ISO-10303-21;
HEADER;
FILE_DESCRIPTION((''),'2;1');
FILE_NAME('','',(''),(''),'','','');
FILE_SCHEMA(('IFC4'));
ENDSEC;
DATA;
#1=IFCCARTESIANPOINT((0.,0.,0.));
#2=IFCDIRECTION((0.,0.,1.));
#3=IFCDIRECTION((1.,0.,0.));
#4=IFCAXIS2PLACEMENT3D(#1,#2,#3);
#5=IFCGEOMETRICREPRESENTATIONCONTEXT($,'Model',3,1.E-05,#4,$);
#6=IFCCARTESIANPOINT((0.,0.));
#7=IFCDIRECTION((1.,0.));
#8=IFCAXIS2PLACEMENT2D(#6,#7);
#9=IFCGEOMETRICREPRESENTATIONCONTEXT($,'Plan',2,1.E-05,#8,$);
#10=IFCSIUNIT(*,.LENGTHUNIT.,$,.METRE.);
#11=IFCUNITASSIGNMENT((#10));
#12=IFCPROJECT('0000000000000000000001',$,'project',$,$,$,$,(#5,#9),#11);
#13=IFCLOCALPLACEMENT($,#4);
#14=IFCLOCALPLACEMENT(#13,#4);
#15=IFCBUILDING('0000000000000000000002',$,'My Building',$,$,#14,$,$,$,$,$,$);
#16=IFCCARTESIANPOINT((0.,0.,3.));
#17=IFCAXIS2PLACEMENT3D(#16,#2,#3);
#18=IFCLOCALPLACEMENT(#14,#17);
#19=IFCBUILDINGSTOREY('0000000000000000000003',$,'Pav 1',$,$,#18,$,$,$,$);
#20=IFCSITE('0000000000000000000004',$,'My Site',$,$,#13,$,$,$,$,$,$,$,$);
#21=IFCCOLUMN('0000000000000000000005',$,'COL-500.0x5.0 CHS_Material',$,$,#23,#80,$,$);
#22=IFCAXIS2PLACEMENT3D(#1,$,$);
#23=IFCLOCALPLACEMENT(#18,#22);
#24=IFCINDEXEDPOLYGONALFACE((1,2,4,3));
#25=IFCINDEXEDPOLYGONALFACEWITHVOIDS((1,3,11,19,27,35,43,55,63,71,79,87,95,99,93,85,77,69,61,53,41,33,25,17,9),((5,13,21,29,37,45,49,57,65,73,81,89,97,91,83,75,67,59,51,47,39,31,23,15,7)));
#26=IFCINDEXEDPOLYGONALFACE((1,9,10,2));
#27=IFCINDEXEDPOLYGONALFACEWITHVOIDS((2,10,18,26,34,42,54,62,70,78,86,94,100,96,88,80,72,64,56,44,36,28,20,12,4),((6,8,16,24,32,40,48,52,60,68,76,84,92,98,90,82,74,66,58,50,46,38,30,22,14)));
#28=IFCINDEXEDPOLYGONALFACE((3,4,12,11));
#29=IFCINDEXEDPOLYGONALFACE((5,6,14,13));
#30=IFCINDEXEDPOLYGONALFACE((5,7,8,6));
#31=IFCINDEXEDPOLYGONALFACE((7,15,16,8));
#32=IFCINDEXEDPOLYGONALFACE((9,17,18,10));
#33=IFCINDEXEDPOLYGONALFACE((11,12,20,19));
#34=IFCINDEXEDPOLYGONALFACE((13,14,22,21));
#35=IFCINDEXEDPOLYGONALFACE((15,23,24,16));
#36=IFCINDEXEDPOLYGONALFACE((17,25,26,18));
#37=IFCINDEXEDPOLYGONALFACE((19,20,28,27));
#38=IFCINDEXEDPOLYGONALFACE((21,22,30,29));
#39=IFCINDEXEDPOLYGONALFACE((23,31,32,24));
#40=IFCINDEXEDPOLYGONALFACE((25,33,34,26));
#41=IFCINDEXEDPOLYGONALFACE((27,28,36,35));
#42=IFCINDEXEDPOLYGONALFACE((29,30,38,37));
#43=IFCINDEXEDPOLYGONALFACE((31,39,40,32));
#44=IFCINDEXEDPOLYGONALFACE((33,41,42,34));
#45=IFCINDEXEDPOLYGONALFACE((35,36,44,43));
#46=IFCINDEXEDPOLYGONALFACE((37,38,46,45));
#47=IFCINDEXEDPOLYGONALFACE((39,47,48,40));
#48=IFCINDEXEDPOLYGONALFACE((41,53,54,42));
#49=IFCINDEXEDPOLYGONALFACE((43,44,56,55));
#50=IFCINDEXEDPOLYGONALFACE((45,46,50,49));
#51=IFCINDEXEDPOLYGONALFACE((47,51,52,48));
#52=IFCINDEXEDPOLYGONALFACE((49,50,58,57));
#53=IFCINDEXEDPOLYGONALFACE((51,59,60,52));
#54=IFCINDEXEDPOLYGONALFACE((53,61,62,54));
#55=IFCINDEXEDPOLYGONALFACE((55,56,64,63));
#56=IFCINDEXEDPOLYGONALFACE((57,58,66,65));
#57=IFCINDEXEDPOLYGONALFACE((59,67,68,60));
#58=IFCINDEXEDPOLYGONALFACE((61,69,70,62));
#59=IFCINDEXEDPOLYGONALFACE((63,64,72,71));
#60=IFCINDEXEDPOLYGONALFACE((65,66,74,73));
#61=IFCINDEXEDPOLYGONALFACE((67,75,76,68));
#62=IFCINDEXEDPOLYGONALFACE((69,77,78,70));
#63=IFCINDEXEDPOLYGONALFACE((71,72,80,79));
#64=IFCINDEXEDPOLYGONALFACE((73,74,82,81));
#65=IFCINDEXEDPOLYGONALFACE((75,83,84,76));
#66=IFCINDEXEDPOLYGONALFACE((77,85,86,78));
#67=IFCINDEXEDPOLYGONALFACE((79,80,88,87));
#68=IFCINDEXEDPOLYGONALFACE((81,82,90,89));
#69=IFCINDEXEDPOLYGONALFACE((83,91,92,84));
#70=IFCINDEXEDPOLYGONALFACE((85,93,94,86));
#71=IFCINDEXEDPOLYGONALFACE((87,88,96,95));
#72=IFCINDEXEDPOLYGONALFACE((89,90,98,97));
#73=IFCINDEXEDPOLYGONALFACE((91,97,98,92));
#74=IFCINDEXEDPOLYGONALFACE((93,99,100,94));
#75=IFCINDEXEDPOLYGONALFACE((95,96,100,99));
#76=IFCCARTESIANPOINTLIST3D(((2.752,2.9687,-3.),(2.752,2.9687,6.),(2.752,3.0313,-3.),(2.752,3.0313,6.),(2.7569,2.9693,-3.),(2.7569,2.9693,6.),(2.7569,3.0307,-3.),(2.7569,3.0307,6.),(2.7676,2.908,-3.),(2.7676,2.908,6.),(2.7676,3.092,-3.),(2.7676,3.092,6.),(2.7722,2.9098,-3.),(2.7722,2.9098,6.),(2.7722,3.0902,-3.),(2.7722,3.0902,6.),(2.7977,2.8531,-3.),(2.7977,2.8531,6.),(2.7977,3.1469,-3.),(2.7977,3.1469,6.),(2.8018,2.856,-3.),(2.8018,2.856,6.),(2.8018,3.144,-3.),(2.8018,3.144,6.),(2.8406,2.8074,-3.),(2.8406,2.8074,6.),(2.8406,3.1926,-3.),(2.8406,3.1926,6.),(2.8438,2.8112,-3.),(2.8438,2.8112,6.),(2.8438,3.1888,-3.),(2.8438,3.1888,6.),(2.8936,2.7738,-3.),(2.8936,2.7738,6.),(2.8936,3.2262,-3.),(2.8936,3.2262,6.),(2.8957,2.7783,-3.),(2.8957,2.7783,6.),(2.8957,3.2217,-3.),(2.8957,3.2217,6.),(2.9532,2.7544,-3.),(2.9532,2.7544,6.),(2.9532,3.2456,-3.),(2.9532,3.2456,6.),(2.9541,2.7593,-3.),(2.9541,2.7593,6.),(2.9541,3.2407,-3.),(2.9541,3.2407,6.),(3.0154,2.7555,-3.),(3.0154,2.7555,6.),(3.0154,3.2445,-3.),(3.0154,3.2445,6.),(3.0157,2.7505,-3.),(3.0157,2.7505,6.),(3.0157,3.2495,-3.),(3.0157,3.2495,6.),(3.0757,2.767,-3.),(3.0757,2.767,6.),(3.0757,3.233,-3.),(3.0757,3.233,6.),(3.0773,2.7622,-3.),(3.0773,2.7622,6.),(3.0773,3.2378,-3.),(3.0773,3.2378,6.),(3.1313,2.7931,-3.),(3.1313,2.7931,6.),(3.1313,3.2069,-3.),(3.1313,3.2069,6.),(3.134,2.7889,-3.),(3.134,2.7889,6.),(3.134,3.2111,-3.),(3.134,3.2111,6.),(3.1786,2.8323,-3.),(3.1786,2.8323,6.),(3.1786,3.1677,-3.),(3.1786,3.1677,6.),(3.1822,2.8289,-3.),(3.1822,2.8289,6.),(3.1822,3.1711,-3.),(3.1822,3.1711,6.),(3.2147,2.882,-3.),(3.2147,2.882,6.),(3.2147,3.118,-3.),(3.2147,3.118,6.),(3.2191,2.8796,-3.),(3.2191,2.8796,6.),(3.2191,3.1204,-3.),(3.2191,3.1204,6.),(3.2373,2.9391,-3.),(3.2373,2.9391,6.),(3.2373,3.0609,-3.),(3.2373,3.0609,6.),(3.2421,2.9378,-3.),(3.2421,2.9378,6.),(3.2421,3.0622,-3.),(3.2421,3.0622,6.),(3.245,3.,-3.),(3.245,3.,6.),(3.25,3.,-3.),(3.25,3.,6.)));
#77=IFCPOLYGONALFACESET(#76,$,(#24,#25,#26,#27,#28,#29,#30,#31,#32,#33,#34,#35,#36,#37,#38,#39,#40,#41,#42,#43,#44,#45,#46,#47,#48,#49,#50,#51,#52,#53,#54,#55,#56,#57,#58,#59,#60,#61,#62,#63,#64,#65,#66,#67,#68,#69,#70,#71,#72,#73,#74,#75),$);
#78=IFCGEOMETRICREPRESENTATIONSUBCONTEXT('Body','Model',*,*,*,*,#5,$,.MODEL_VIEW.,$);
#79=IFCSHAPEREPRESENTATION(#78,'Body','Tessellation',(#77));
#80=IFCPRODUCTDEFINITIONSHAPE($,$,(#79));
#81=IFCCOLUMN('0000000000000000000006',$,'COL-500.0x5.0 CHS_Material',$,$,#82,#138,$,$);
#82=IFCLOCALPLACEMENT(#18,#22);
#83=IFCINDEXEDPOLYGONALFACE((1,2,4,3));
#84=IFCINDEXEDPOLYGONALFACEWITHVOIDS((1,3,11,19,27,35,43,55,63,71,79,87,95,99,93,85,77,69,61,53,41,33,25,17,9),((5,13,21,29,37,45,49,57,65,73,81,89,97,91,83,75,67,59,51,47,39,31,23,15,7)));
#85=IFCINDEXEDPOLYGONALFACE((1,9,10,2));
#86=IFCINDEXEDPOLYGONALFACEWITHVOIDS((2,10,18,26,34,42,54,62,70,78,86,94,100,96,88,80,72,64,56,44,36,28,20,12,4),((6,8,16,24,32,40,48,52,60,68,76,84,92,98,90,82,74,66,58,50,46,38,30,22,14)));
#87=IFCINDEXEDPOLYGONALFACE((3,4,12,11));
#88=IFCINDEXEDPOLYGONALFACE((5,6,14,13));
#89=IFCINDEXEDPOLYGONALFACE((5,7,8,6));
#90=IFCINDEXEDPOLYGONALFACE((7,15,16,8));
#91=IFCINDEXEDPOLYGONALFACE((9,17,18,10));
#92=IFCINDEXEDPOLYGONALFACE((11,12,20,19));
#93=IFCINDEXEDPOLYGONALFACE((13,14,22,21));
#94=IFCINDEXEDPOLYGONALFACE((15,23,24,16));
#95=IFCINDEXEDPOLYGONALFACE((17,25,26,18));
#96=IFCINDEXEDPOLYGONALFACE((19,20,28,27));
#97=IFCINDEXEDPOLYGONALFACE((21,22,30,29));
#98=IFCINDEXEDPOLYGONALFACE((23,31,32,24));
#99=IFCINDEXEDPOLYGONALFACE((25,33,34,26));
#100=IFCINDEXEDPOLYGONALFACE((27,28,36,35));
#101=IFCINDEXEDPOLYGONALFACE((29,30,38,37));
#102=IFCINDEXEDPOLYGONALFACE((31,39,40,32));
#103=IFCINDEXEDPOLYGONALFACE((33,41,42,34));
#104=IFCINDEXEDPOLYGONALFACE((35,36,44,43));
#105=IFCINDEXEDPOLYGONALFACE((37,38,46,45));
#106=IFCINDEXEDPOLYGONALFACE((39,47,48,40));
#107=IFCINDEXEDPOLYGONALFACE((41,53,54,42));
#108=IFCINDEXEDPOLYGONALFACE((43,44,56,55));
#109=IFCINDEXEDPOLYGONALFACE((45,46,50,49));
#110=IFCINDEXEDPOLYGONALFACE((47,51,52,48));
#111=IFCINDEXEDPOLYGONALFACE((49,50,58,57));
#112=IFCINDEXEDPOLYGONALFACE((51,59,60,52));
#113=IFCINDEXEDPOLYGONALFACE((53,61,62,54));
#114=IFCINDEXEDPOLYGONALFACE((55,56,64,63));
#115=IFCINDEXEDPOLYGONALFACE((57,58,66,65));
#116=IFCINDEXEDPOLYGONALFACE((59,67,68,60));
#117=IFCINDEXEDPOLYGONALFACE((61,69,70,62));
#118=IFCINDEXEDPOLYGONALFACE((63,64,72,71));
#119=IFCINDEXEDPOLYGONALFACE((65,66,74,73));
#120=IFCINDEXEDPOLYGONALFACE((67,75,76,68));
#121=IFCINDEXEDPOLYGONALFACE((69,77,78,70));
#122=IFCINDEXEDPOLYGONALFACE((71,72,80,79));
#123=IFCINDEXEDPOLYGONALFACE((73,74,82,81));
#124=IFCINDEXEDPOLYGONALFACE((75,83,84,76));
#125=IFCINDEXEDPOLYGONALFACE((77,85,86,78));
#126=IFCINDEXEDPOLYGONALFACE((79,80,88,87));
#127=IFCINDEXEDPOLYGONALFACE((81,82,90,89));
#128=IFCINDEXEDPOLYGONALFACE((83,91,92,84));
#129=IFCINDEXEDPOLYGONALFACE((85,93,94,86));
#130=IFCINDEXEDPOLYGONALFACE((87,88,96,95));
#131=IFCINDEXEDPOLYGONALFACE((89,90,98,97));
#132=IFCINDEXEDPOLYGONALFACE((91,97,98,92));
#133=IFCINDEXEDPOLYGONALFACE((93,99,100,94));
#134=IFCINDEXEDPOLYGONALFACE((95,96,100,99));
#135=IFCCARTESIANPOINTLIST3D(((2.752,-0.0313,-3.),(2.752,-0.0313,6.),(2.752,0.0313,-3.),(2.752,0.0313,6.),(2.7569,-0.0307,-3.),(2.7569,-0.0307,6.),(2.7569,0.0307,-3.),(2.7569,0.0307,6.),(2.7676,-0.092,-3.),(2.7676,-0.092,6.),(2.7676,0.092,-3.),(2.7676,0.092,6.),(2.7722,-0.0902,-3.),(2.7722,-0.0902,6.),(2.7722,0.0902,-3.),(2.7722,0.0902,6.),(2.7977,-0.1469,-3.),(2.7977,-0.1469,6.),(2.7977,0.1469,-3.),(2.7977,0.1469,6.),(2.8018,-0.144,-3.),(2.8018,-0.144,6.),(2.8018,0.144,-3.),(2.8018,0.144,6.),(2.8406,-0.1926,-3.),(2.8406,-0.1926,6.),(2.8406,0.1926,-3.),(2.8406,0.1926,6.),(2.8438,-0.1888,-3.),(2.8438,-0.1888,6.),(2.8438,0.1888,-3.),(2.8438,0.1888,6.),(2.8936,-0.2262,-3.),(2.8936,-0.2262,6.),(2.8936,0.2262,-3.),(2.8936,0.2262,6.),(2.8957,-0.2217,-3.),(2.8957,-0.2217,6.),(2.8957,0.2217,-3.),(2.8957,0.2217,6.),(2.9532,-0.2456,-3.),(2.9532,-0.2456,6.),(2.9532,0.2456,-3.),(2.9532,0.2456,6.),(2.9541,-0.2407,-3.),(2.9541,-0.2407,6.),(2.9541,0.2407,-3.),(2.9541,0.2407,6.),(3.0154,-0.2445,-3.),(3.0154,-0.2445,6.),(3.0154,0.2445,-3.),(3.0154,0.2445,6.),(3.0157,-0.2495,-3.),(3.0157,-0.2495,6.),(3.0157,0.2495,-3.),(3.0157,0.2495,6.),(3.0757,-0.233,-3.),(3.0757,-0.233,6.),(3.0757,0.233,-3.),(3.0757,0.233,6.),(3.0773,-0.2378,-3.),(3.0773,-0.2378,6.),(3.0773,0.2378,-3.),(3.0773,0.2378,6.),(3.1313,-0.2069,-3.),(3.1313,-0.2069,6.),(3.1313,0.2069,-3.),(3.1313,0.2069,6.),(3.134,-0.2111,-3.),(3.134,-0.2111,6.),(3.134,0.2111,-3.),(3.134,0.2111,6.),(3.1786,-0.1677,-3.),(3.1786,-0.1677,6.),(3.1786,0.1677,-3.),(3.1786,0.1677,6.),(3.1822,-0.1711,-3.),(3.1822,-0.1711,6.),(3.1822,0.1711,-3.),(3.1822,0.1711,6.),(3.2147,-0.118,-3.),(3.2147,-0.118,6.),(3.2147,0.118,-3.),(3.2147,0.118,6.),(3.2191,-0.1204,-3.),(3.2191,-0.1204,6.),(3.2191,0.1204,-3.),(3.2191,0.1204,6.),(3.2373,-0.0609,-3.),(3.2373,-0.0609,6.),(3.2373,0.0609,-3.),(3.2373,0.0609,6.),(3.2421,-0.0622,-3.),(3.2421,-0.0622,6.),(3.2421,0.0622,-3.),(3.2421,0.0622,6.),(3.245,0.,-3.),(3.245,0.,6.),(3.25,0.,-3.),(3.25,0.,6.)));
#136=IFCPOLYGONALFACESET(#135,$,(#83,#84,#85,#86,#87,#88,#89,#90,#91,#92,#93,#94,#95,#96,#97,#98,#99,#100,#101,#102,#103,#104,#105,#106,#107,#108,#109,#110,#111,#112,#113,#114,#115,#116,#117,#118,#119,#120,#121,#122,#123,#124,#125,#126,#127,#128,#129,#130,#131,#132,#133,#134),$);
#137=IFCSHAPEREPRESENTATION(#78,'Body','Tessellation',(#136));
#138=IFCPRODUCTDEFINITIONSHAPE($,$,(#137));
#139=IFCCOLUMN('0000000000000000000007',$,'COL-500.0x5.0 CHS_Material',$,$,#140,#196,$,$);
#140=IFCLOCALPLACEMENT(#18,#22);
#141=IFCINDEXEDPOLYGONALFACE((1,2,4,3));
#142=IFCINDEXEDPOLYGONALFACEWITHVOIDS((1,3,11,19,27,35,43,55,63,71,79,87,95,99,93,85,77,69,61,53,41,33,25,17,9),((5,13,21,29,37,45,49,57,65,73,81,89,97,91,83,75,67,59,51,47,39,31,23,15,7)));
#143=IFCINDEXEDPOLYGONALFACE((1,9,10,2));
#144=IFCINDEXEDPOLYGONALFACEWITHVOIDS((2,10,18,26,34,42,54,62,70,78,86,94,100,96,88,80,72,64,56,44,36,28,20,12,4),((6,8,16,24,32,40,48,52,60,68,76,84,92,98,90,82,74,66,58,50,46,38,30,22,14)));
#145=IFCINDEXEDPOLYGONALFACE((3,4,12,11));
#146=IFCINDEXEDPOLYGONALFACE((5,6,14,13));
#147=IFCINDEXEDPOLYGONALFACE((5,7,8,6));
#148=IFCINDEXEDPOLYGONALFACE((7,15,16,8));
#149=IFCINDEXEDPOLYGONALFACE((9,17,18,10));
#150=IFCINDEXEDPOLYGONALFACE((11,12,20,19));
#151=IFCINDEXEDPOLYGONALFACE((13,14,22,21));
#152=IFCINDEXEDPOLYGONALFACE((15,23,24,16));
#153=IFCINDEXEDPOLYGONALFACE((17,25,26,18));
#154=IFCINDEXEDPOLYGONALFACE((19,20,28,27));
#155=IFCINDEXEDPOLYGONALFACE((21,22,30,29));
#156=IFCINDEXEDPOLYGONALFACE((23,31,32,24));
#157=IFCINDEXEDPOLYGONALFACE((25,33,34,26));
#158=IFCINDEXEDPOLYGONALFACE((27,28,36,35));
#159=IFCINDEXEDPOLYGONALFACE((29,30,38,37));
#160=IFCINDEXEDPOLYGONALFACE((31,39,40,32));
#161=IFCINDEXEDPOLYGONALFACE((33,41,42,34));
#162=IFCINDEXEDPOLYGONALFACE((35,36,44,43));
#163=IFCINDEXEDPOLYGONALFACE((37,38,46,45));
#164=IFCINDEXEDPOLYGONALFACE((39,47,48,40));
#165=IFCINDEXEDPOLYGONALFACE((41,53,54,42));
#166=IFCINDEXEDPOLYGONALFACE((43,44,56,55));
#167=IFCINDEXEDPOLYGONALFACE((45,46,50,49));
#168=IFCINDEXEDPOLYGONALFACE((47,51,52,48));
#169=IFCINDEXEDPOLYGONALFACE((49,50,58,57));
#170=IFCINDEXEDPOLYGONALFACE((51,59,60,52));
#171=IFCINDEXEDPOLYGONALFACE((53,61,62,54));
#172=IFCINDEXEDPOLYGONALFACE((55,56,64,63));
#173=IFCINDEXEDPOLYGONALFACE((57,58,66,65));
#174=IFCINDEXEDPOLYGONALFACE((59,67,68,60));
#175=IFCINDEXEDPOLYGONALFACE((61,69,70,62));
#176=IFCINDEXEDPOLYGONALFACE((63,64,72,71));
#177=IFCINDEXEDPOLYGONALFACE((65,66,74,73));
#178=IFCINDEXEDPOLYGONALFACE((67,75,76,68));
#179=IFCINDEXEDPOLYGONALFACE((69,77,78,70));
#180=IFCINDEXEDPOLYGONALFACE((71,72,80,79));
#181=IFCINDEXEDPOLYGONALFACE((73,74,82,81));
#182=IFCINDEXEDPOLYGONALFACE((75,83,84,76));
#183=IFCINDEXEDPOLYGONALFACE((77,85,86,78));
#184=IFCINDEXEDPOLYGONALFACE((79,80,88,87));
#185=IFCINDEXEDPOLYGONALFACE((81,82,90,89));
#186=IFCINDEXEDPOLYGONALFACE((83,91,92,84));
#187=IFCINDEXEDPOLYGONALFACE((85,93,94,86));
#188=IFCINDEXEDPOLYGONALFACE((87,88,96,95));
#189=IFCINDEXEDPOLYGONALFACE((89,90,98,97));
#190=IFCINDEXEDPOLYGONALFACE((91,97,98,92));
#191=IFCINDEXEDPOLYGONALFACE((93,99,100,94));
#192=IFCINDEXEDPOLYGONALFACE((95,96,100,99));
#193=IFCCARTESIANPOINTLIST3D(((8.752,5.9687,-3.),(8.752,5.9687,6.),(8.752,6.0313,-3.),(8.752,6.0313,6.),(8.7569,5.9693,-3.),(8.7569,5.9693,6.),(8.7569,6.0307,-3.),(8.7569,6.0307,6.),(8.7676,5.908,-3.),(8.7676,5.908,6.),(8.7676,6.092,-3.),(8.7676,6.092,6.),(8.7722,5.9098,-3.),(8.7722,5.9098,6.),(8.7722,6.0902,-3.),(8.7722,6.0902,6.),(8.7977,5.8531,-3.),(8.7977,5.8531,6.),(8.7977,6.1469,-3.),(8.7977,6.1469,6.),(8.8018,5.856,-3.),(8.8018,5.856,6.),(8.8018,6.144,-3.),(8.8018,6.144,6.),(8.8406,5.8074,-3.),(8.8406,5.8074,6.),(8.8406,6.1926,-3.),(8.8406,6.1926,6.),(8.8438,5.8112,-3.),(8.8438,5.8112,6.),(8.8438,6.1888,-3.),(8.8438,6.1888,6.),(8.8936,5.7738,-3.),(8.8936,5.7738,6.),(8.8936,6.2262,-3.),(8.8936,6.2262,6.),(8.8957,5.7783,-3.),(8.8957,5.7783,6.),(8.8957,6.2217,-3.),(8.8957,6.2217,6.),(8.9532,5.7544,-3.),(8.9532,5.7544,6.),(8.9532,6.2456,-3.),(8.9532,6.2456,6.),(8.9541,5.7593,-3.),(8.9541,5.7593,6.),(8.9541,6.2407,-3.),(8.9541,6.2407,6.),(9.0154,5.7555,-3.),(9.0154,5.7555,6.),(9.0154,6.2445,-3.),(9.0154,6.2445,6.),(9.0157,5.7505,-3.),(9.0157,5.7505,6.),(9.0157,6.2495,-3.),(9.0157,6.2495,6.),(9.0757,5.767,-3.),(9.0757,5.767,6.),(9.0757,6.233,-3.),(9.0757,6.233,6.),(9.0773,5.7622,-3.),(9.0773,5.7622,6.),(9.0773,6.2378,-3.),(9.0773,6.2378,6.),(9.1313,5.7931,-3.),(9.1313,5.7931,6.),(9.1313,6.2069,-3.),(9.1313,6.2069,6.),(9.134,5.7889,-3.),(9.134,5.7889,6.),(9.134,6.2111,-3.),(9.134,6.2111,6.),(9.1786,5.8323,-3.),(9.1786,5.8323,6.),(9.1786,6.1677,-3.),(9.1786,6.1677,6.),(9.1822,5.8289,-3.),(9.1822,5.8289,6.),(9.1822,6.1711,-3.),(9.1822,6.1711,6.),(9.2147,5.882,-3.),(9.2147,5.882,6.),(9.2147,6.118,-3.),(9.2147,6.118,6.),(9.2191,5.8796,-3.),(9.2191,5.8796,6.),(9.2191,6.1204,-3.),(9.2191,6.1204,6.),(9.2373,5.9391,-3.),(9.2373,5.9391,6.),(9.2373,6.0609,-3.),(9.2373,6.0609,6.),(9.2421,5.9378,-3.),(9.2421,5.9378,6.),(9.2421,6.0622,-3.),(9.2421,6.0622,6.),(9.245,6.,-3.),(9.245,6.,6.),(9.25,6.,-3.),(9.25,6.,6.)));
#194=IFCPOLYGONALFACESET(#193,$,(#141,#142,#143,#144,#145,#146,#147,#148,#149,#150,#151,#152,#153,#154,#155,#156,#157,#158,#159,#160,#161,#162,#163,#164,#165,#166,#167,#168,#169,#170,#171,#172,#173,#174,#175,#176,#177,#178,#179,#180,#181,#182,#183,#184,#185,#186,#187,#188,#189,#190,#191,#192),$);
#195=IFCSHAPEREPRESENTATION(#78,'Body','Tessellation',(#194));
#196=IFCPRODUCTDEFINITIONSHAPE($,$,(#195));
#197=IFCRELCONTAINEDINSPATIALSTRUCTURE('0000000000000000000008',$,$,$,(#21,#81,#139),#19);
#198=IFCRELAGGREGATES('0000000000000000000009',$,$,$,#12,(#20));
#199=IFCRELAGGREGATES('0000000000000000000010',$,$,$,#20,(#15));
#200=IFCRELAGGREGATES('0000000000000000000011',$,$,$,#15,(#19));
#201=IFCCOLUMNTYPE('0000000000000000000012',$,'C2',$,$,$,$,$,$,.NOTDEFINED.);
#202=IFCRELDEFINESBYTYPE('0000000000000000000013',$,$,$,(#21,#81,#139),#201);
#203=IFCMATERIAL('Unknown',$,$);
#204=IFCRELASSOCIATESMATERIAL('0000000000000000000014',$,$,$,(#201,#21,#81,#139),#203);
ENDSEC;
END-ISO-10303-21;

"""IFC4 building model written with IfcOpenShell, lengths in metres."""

from ifc_helpers import new_model, si_unit, frame, origin, origin_with_axes, origin_2d_with_axis, place, context, subcontext, project, spatial, hollow_circle, extrude, material, material_profile, profile_set, profile_usage, type_object, element, save


model = new_model("IFC4")

# Units and contexts
model_context = context("Model", 3, precision=1e-05, world=origin_with_axes())
plan_context = context("Plan", 2, precision=1e-05, world=origin_2d_with_axis())
body_context = subcontext(model_context, "Body", "Model", "MODEL_VIEW")
ifc_project = project(units=[si_unit("LENGTHUNIT", "METRE")], contexts=[model_context, plan_context])

# Site, building, storey
site_placement = place(None, origin_with_axes())
site = spatial("IfcSite", under=ifc_project, at=site_placement, Name="My Site")
building_placement = place(site_placement, origin_with_axes())
building = spatial("IfcBuilding", under=site, at=building_placement, Name="My Building")
storey_placement = place(building_placement, frame((0.0, 0.0, 3.0), z_axis=(0.0, 0.0, 1.0), x_axis=(1.0, 0.0, 0.0)))
storey = spatial("IfcBuildingStorey", under=building, at=storey_placement, Name="Pav 1")

# Columns
ifc_material = material(Name="Unknown")
ifc_material_profile = material_profile(ifc_material, hollow_circle(Radius=0.25, WallThickness=0.005))
ifc_profile_set = profile_set([ifc_material_profile])
ifc_profile_usage_1 = profile_usage(ifc_profile_set, cardinal=5)
column_type = type_object("IfcColumnType", Name="C2", PredefinedType="NOTDEFINED", material=ifc_profile_set)
column_1_placement = place(storey_placement, frame((3.0, 3.0, -3.0), z_axis=(0.0, 0.0, 1.0), x_axis=(1.0, 0.0, 0.0)))
element("IfcColumn", 1, at=column_1_placement, inside=storey, type_object=column_type, material=ifc_profile_usage_1, Name="COL-500.0x5.0 CHS_Material", context=body_context, shape_type="SweptSolid", body=[
    extrude(hollow_circle(Radius=0.25, WallThickness=0.005), origin(), (0.0, 0.0, 1.0), 9.0),
])
ifc_profile_usage_2 = profile_usage(ifc_profile_set, cardinal=5)
column_2_placement = place(storey_placement, frame((3.0, 0.0, -3.0), z_axis=(0.0, 0.0, 1.0), x_axis=(1.0, 0.0, 0.0)))
element("IfcColumn", 2, at=column_2_placement, inside=storey, type_object=column_type, material=ifc_profile_usage_2, Name="COL-500.0x5.0 CHS_Material", context=body_context, shape_type="SweptSolid", body=[
    extrude(hollow_circle(Radius=0.25, WallThickness=0.005), origin(), (0.0, 0.0, 1.0), 9.0),
])
ifc_profile_usage_3 = profile_usage(ifc_profile_set, cardinal=5)
column_3_placement = place(storey_placement, frame((9.0, 6.0, -3.0), z_axis=(0.0, 0.0, 1.0), x_axis=(1.0, 0.0, 0.0)))
element("IfcColumn", 3, at=column_3_placement, inside=storey, type_object=column_type, material=ifc_profile_usage_3, Name="COL-500.0x5.0 CHS_Material", context=body_context, shape_type="SweptSolid", body=[
    extrude(hollow_circle(Radius=0.25, WallThickness=0.005), origin(), (0.0, 0.0, 1.0), 9.0),
])

save(model, "model.ifc")
